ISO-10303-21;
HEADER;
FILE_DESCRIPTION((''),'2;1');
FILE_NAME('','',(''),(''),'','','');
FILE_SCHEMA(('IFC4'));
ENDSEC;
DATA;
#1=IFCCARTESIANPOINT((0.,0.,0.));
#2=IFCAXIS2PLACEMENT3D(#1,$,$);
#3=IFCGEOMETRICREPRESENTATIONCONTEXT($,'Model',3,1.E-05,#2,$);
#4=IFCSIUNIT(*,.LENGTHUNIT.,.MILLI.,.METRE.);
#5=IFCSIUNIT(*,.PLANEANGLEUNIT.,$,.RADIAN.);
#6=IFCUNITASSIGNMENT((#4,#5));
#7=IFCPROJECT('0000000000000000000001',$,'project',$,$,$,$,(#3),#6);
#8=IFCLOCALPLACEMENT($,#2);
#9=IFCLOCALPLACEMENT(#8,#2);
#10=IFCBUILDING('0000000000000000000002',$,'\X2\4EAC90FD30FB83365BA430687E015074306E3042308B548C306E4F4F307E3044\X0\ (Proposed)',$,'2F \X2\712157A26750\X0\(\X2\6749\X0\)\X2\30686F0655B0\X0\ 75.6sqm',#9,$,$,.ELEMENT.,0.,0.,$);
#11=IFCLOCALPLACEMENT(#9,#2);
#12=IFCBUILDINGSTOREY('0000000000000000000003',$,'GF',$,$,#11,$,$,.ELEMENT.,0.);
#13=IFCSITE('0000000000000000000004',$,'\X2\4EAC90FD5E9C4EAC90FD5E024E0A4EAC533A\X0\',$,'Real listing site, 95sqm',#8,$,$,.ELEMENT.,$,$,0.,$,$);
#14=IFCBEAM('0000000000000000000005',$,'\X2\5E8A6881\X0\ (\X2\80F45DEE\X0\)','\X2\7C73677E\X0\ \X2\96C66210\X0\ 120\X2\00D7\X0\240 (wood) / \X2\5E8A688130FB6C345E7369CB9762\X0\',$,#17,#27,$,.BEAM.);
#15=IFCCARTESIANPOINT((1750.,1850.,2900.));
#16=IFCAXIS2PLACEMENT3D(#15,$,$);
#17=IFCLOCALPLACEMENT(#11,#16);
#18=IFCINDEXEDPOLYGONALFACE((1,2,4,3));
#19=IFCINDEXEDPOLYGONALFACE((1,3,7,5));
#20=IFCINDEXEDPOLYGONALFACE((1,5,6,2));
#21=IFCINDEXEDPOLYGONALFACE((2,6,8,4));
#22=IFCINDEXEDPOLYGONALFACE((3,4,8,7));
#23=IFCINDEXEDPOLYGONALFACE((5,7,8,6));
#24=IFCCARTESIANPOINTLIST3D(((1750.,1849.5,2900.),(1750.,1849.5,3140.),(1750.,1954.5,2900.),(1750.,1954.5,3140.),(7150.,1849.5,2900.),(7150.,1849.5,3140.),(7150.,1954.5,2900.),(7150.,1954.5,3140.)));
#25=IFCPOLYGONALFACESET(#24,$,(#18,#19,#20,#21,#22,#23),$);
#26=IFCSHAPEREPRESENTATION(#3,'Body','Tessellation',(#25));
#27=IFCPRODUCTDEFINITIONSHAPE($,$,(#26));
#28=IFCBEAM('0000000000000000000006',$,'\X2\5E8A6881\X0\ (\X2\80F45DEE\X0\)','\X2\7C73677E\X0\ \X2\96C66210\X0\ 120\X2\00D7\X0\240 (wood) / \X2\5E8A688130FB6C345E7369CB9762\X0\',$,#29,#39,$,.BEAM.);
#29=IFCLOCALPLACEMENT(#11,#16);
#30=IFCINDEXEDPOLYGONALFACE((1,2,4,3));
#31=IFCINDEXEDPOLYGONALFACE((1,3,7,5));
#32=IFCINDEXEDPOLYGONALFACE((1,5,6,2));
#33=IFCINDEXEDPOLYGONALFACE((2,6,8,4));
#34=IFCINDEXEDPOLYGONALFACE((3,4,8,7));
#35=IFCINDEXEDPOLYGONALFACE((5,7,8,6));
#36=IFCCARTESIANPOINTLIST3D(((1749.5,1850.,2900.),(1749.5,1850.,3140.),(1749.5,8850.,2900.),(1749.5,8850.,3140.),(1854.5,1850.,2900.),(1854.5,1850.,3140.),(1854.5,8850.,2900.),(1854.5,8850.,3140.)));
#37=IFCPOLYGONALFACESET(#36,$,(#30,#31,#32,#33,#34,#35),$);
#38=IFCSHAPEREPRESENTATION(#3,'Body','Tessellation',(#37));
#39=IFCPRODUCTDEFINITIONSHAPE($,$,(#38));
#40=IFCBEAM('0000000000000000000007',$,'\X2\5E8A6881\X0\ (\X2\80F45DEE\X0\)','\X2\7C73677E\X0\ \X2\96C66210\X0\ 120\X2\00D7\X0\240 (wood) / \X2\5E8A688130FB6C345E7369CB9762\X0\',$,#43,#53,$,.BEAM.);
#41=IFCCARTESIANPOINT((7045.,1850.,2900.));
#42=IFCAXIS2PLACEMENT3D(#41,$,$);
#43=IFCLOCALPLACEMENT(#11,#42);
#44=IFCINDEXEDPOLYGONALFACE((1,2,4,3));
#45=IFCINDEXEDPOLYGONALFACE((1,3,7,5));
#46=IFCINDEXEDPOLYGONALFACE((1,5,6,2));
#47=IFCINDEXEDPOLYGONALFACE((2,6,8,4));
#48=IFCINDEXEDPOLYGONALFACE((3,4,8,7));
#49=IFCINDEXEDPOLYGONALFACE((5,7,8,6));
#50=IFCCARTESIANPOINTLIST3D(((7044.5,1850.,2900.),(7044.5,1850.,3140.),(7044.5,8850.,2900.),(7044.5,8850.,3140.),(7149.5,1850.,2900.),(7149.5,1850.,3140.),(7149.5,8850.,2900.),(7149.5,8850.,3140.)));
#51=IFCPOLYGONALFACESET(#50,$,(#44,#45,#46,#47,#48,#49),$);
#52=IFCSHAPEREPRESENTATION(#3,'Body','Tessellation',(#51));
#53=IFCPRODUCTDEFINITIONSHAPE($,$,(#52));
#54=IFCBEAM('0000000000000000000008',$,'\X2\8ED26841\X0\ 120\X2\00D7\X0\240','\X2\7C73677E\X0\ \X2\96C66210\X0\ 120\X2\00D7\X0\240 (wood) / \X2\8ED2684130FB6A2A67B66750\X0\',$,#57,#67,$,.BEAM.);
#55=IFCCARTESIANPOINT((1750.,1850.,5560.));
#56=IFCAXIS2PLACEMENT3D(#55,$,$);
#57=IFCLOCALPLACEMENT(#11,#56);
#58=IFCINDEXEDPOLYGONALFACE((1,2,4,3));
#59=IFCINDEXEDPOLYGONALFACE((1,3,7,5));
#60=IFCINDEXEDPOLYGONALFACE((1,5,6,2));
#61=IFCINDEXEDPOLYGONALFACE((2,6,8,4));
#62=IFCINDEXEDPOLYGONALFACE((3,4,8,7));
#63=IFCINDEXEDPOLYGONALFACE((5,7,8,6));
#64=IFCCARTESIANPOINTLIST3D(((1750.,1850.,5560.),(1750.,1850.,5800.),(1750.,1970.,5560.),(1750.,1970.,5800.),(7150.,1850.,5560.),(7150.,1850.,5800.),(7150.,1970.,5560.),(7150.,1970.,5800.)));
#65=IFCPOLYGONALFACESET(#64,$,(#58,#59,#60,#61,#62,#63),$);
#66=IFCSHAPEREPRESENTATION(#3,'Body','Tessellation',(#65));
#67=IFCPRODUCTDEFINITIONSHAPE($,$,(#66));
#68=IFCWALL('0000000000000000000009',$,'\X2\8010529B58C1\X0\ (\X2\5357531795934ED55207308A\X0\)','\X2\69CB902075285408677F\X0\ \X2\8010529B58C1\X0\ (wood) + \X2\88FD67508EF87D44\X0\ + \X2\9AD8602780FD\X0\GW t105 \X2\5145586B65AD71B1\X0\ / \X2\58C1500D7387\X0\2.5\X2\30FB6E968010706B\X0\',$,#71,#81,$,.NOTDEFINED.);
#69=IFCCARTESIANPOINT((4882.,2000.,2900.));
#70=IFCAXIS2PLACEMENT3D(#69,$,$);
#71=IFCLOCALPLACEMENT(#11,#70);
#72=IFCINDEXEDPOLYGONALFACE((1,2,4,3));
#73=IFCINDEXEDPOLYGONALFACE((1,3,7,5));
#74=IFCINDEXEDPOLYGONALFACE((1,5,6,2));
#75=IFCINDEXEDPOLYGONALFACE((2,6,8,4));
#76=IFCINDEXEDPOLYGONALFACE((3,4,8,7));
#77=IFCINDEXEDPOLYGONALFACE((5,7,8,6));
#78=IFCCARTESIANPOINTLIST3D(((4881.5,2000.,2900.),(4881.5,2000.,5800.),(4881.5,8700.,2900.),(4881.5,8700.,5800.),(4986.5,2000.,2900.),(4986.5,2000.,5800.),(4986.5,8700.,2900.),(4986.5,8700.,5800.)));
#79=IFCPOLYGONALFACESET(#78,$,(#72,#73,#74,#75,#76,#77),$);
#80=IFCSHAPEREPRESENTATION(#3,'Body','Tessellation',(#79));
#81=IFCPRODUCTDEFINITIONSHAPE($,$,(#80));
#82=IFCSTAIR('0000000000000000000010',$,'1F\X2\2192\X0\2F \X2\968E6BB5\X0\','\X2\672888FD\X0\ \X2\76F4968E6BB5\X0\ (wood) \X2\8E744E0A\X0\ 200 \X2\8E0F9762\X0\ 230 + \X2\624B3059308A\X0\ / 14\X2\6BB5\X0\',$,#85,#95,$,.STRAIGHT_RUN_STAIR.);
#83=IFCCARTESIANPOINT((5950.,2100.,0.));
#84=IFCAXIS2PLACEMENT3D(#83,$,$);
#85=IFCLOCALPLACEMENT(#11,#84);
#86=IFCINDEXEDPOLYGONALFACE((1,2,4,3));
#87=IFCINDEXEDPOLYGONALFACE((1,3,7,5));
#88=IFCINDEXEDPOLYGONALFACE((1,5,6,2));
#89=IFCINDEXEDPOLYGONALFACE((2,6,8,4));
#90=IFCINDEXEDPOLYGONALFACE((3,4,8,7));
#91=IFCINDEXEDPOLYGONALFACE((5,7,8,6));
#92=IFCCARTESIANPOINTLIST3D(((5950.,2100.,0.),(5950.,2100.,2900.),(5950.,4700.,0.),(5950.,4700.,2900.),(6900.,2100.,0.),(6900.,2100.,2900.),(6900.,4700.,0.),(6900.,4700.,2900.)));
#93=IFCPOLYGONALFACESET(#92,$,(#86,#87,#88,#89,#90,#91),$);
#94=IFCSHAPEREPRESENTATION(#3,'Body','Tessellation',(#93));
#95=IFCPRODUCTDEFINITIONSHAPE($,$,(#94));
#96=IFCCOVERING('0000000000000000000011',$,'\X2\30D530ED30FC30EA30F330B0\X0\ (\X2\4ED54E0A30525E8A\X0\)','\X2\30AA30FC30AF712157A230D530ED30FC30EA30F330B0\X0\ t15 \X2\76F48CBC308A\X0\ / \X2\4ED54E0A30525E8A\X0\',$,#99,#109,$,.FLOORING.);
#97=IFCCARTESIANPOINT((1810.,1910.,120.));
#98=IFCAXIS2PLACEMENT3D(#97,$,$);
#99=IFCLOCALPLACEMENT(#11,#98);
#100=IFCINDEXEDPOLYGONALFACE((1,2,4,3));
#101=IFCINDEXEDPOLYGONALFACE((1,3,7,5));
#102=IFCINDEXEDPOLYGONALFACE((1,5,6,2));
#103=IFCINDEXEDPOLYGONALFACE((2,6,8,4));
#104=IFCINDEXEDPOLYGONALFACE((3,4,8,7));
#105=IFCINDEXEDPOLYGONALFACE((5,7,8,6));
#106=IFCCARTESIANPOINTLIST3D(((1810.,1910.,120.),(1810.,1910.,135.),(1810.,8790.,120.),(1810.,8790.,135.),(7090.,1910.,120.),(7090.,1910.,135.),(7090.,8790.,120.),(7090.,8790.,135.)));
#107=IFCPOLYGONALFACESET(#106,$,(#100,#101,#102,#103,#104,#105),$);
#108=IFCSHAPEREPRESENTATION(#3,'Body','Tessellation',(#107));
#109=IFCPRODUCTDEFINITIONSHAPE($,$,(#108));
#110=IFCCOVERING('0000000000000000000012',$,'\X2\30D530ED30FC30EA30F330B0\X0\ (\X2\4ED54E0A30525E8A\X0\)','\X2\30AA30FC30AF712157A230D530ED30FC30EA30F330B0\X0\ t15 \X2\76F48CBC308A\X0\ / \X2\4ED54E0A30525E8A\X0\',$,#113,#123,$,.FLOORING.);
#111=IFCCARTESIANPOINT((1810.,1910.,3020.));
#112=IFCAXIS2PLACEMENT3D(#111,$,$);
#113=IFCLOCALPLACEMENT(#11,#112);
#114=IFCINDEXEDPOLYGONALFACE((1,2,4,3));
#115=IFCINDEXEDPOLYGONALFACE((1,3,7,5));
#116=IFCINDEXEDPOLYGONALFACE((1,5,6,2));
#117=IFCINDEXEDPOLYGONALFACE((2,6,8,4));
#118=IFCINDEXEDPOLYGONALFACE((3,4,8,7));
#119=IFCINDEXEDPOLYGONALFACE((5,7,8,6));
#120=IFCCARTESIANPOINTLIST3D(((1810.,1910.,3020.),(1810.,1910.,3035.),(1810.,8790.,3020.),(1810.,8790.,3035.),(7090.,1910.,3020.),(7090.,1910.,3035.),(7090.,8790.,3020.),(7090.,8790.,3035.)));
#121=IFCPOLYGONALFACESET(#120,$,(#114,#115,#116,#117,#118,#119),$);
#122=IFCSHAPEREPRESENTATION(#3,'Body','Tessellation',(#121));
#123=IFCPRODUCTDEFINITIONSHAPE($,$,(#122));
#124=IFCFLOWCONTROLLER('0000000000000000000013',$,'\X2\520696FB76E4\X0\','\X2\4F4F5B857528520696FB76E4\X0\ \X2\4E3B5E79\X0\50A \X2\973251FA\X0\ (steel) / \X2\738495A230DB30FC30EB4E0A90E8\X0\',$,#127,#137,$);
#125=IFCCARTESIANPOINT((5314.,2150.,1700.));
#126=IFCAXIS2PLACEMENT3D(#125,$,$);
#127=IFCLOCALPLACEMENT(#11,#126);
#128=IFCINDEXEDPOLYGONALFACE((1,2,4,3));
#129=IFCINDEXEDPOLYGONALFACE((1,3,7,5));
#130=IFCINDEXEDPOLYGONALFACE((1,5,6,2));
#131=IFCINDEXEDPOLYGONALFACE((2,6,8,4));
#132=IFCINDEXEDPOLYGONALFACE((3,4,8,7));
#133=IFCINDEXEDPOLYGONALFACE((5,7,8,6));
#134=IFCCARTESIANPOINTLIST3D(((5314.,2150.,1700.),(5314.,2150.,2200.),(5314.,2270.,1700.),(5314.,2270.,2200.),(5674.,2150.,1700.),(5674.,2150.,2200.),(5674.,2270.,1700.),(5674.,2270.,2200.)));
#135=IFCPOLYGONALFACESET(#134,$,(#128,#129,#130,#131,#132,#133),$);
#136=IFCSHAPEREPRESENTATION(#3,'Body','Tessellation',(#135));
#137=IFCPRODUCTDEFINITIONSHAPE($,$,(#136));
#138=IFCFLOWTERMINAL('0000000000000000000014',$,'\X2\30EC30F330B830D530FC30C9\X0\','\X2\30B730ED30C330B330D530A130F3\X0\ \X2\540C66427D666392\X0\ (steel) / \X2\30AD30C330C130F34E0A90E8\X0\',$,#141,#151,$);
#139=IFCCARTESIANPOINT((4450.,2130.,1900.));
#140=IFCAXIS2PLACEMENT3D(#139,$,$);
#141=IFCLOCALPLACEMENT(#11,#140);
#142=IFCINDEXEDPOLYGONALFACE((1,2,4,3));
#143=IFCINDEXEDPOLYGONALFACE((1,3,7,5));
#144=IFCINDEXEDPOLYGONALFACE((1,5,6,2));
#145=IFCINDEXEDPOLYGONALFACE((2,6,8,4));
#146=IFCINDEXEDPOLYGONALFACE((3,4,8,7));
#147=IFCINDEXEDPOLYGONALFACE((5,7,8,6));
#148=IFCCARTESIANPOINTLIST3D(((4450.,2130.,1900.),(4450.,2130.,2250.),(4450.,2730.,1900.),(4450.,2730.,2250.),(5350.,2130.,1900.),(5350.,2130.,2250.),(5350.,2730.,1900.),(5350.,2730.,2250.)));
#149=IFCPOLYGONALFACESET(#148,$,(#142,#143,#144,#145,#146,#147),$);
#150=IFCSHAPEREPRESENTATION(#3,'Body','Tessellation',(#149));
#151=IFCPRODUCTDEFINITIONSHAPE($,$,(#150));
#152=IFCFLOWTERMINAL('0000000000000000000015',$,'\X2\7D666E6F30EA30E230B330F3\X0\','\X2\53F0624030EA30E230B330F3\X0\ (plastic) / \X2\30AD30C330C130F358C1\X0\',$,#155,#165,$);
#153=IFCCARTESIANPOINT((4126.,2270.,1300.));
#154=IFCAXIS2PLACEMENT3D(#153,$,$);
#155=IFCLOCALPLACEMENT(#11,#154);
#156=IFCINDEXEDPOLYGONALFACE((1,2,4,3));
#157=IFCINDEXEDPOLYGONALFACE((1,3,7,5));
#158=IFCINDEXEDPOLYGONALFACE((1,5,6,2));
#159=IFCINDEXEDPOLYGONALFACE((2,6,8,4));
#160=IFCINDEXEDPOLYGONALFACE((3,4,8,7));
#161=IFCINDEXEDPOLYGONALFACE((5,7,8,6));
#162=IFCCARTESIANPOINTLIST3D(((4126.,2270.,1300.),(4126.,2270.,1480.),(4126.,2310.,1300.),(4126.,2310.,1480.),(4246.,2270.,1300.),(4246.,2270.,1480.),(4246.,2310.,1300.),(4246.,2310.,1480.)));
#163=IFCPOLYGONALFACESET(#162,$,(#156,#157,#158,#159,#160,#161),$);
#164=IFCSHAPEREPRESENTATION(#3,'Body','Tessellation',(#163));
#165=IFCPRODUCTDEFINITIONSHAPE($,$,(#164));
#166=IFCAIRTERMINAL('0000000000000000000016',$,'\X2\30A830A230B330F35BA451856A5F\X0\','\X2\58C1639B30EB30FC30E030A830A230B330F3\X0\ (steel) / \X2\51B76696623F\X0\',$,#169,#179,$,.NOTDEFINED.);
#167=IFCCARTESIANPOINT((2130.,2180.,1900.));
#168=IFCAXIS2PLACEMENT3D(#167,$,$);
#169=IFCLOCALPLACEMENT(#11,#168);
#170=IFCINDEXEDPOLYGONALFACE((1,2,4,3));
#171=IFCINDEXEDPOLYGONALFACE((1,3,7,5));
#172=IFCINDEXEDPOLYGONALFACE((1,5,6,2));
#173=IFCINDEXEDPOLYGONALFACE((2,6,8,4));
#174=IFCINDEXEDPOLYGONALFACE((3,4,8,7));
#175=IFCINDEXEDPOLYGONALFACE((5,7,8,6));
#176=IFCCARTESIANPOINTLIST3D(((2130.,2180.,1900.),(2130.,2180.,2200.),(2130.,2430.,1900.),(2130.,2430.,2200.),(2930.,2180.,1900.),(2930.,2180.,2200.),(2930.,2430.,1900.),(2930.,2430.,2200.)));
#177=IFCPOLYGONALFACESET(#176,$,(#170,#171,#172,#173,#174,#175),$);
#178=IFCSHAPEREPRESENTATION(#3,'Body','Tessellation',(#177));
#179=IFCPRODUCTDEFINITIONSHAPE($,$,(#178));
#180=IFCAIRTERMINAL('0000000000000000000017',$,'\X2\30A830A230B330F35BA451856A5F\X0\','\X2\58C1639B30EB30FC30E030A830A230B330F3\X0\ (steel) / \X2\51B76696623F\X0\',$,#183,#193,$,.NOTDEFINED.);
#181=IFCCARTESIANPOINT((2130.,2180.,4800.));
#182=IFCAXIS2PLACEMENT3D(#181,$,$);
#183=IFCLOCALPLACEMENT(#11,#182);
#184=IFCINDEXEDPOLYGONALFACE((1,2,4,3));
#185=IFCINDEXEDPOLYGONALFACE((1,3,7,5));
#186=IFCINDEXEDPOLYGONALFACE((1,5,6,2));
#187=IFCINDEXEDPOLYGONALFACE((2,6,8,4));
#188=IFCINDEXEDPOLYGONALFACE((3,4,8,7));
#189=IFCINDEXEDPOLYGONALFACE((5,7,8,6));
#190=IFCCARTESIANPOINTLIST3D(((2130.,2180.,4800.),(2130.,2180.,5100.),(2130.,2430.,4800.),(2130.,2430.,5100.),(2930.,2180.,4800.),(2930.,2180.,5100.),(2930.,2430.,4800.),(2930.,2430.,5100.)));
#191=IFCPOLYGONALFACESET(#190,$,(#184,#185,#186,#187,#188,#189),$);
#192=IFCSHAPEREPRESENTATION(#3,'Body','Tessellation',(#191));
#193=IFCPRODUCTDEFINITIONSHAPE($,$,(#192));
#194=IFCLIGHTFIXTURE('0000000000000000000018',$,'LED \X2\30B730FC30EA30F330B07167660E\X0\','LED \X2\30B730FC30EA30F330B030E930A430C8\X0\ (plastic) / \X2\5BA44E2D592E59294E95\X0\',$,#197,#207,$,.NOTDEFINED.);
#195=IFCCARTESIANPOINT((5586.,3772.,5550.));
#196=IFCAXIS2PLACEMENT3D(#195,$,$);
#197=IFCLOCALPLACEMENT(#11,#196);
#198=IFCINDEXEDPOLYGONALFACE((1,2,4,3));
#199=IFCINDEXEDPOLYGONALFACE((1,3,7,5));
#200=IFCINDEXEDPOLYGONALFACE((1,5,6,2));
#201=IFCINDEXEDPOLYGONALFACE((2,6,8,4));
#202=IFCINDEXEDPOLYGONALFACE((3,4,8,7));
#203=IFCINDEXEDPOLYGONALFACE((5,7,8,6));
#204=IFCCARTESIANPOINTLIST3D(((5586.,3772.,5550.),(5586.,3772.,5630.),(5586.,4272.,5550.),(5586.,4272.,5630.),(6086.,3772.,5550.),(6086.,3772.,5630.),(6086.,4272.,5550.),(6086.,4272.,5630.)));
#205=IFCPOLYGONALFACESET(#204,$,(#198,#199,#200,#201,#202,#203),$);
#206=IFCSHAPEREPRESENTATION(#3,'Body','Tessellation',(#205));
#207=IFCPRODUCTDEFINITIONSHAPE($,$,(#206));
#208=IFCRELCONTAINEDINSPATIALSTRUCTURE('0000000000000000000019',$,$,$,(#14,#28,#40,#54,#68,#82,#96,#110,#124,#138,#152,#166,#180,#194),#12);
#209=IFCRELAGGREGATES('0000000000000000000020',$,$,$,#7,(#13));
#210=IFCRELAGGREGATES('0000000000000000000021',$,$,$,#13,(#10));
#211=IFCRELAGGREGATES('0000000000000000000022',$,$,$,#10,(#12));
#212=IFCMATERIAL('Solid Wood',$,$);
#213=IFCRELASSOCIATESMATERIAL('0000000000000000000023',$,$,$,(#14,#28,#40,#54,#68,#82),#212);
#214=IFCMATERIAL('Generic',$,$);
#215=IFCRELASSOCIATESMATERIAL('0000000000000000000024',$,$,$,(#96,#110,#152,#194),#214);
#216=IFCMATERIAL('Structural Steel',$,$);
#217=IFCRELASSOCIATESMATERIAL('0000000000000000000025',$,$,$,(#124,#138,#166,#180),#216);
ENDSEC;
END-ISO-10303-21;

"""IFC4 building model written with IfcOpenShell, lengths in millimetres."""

from ifc_helpers import new_model, si_unit, frame, frame_2d, origin, place, context, project, spatial, rectangle, extrude, material, element, save


model = new_model("IFC4")

# Units and contexts
model_context = context("Model", 3, precision=1e-05, world=origin())
ifc_project = project(units=[si_unit("LENGTHUNIT", "METRE", prefix="MILLI"), si_unit("PLANEANGLEUNIT", "RADIAN")], contexts=[model_context])

# Site, building, storey
site_placement = place(None, origin())
site = spatial("IfcSite", under=ifc_project, at=site_placement, Name="京都府京都市上京区", ObjectType="Real listing site, 95sqm", CompositionType="ELEMENT", RefElevation=0.0)
building_placement = place(site_placement, origin())
building = spatial("IfcBuilding", under=site, at=building_placement, Name="京都・茶室と縁側のある和の住まい (Proposed)", ObjectType="2F 無垢材(杉)と漆喰 75.6sqm", CompositionType="ELEMENT", ElevationOfRefHeight=0.0, ElevationOfTerrain=0.0)
storey_placement = place(building_placement, origin())
storey = spatial("IfcBuildingStorey", under=building, at=storey_placement, Name="GF", CompositionType="ELEMENT", Elevation=0.0)

# Shared definitions
ifc_material_1 = material(Name="Solid Wood")

# Beams
beam_1_placement = place(storey_placement, frame((1750.0, 1850.0, 2900.0)))
element("IfcBeam", 1, at=beam_1_placement, inside=storey, material=ifc_material_1, Name="床梁 (胴差)", Description="米松 集成 120×240 (wood) / 床梁・水平構面", PredefinedType="BEAM", context=model_context, shape_type="SweptSolid", body=[
    extrude(rectangle(XDim=5400.0, YDim=105.0, at=frame_2d((2700.0, 52.0))), frame((1750.0, 1850.0, 2900.0)), (0.0, 0.0, 1.0), 240.0),
])
beam_2_placement = place(storey_placement, frame((1750.0, 1850.0, 2900.0)))
element("IfcBeam", 2, at=beam_2_placement, inside=storey, material=ifc_material_1, Name="床梁 (胴差)", Description="米松 集成 120×240 (wood) / 床梁・水平構面", PredefinedType="BEAM", context=model_context, shape_type="SweptSolid", body=[
    extrude(rectangle(XDim=105.0, YDim=7000.0, at=frame_2d((52.0, 3500.0))), frame((1750.0, 1850.0, 2900.0)), (0.0, 0.0, 1.0), 240.0),
])
beam_3_placement = place(storey_placement, frame((7045.0, 1850.0, 2900.0)))
element("IfcBeam", 3, at=beam_3_placement, inside=storey, material=ifc_material_1, Name="床梁 (胴差)", Description="米松 集成 120×240 (wood) / 床梁・水平構面", PredefinedType="BEAM", context=model_context, shape_type="SweptSolid", body=[
    extrude(rectangle(XDim=105.0, YDim=7000.0, at=frame_2d((52.0, 3500.0))), frame((7045.0, 1850.0, 2900.0)), (0.0, 0.0, 1.0), 240.0),
])
beam_4_placement = place(storey_placement, frame((1750.0, 1850.0, 5560.0)))
element("IfcBeam", 4, at=beam_4_placement, inside=storey, material=ifc_material_1, Name="軒桁 120×240", Description="米松 集成 120×240 (wood) / 軒桁・横架材", PredefinedType="BEAM", context=model_context, shape_type="SweptSolid", body=[
    extrude(rectangle(XDim=5400.0, YDim=120.0, at=frame_2d((2700.0, 60.0))), frame((1750.0, 1850.0, 5560.0)), (0.0, 0.0, 1.0), 240.0),
])

# Wall
wall_1_placement = place(storey_placement, frame((4882.0, 2000.0, 2900.0)))
element("IfcWall", 5, at=wall_1_placement, inside=storey, material=ifc_material_1, Name="耐力壁 (南北間仕切り)", Description="構造用合板 耐力壁 (wood) + 製材軸組 + 高性能GW t105 充填断熱 / 壁倍率2.5・準耐火", PredefinedType="NOTDEFINED", context=model_context, shape_type="SweptSolid", body=[
    extrude(rectangle(XDim=105.0, YDim=6700.0, at=frame_2d((52.0, 3350.0))), frame((4882.0, 2000.0, 2900.0)), (0.0, 0.0, 1.0), 2900.0),
])

# Stair
stair_placement = place(storey_placement, frame((5950.0, 2100.0, 0.0)))
element("IfcStair", 6, at=stair_placement, inside=storey, material=ifc_material_1, Name="1F→2F 階段", Description="木製 直階段 (wood) 蹴上 200 踏面 230 + 手すり / 14段", PredefinedType="STRAIGHT_RUN_STAIR", context=model_context, shape_type="SweptSolid", body=[
    extrude(rectangle(XDim=950.0, YDim=2600.0, at=frame_2d((475.0, 1300.0))), frame((5950.0, 2100.0, 0.0)), (0.0, 0.0, 1.0), 2900.0),
])

# Coverings
ifc_material_2 = material(Name="Generic")
covering_1_placement = place(storey_placement, frame((1810.0, 1910.0, 120.0)))
element("IfcCovering", 7, at=covering_1_placement, inside=storey, material=ifc_material_2, Name="フローリング (仕上げ床)", Description="オーク無垢フローリング t15 直貼り / 仕上げ床", PredefinedType="FLOORING", context=model_context, shape_type="SweptSolid", body=[
    extrude(rectangle(XDim=5280.0, YDim=6880.0, at=frame_2d((2640.0, 3440.0))), frame((1810.0, 1910.0, 120.0)), (0.0, 0.0, 1.0), 15.0),
])
covering_2_placement = place(storey_placement, frame((1810.0, 1910.0, 3020.0)))
element("IfcCovering", 8, at=covering_2_placement, inside=storey, material=ifc_material_2, Name="フローリング (仕上げ床)", Description="オーク無垢フローリング t15 直貼り / 仕上げ床", PredefinedType="FLOORING", context=model_context, shape_type="SweptSolid", body=[
    extrude(rectangle(XDim=5280.0, YDim=6880.0, at=frame_2d((2640.0, 3440.0))), frame((1810.0, 1910.0, 3020.0)), (0.0, 0.0, 1.0), 15.0),
])

# Flow controller
ifc_material_3 = material(Name="Structural Steel")
flow_controller_placement = place(storey_placement, frame((5314.0, 2150.0, 1700.0)))
element("IfcFlowController", 9, at=flow_controller_placement, inside=storey, material=ifc_material_3, Name="分電盤", Description="住宅用分電盤 主幹50A 露出 (steel) / 玄関ホール上部", context=model_context, shape_type="SweptSolid", body=[
    extrude(rectangle(XDim=360.0, YDim=120.0, at=frame_2d((180.0, 60.0))), frame((5314.0, 2150.0, 1700.0)), (0.0, 0.0, 1.0), 500.0),
])

# Flow terminals
flow_terminal_1_placement = place(storey_placement, frame((4450.0, 2130.0, 1900.0)))
element("IfcFlowTerminal", 10, at=flow_terminal_1_placement, inside=storey, material=ifc_material_3, Name="レンジフード", Description="シロッコファン 同時給排 (steel) / キッチン上部", context=model_context, shape_type="SweptSolid", body=[
    extrude(rectangle(XDim=900.0, YDim=600.0, at=frame_2d((450.0, 300.0))), frame((4450.0, 2130.0, 1900.0)), (0.0, 0.0, 1.0), 350.0),
])
flow_terminal_2_placement = place(storey_placement, frame((4126.0, 2270.0, 1300.0)))
element("IfcFlowTerminal", 11, at=flow_terminal_2_placement, inside=storey, material=ifc_material_2, Name="給湯リモコン", Description="台所リモコン (plastic) / キッチン壁", context=model_context, shape_type="SweptSolid", body=[
    extrude(rectangle(XDim=120.0, YDim=40.0, at=frame_2d((60.0, 20.0))), frame((4126.0, 2270.0, 1300.0)), (0.0, 0.0, 1.0), 180.0),
])

# Air terminals
air_terminal_1_placement = place(storey_placement, frame((2130.0, 2180.0, 1900.0)))
element("IfcAirTerminal", 12, at=air_terminal_1_placement, inside=storey, material=ifc_material_3, Name="エアコン室内機", Description="壁掛ルームエアコン (steel) / 冷暖房", PredefinedType="NOTDEFINED", context=model_context, shape_type="SweptSolid", body=[
    extrude(rectangle(XDim=800.0, YDim=250.0, at=frame_2d((400.0, 125.0))), frame((2130.0, 2180.0, 1900.0)), (0.0, 0.0, 1.0), 300.0),
])
air_terminal_2_placement = place(storey_placement, frame((2130.0, 2180.0, 4800.0)))
element("IfcAirTerminal", 13, at=air_terminal_2_placement, inside=storey, material=ifc_material_3, Name="エアコン室内機", Description="壁掛ルームエアコン (steel) / 冷暖房", PredefinedType="NOTDEFINED", context=model_context, shape_type="SweptSolid", body=[
    extrude(rectangle(XDim=800.0, YDim=250.0, at=frame_2d((400.0, 125.0))), frame((2130.0, 2180.0, 4800.0)), (0.0, 0.0, 1.0), 300.0),
])

# Light fixture
light_fixture_placement = place(storey_placement, frame((5586.0, 3772.0, 5550.0)))
element("IfcLightFixture", 14, at=light_fixture_placement, inside=storey, material=ifc_material_2, Name="LED シーリング照明", Description="LED シーリングライト (plastic) / 室中央天井", PredefinedType="NOTDEFINED", context=model_context, shape_type="SweptSolid", body=[
    extrude(rectangle(XDim=500.0, YDim=500.0, at=frame_2d((250.0, 250.0))), frame((5586.0, 3772.0, 5550.0)), (0.0, 0.0, 1.0), 80.0),
])

save(model, "model.ifc")
